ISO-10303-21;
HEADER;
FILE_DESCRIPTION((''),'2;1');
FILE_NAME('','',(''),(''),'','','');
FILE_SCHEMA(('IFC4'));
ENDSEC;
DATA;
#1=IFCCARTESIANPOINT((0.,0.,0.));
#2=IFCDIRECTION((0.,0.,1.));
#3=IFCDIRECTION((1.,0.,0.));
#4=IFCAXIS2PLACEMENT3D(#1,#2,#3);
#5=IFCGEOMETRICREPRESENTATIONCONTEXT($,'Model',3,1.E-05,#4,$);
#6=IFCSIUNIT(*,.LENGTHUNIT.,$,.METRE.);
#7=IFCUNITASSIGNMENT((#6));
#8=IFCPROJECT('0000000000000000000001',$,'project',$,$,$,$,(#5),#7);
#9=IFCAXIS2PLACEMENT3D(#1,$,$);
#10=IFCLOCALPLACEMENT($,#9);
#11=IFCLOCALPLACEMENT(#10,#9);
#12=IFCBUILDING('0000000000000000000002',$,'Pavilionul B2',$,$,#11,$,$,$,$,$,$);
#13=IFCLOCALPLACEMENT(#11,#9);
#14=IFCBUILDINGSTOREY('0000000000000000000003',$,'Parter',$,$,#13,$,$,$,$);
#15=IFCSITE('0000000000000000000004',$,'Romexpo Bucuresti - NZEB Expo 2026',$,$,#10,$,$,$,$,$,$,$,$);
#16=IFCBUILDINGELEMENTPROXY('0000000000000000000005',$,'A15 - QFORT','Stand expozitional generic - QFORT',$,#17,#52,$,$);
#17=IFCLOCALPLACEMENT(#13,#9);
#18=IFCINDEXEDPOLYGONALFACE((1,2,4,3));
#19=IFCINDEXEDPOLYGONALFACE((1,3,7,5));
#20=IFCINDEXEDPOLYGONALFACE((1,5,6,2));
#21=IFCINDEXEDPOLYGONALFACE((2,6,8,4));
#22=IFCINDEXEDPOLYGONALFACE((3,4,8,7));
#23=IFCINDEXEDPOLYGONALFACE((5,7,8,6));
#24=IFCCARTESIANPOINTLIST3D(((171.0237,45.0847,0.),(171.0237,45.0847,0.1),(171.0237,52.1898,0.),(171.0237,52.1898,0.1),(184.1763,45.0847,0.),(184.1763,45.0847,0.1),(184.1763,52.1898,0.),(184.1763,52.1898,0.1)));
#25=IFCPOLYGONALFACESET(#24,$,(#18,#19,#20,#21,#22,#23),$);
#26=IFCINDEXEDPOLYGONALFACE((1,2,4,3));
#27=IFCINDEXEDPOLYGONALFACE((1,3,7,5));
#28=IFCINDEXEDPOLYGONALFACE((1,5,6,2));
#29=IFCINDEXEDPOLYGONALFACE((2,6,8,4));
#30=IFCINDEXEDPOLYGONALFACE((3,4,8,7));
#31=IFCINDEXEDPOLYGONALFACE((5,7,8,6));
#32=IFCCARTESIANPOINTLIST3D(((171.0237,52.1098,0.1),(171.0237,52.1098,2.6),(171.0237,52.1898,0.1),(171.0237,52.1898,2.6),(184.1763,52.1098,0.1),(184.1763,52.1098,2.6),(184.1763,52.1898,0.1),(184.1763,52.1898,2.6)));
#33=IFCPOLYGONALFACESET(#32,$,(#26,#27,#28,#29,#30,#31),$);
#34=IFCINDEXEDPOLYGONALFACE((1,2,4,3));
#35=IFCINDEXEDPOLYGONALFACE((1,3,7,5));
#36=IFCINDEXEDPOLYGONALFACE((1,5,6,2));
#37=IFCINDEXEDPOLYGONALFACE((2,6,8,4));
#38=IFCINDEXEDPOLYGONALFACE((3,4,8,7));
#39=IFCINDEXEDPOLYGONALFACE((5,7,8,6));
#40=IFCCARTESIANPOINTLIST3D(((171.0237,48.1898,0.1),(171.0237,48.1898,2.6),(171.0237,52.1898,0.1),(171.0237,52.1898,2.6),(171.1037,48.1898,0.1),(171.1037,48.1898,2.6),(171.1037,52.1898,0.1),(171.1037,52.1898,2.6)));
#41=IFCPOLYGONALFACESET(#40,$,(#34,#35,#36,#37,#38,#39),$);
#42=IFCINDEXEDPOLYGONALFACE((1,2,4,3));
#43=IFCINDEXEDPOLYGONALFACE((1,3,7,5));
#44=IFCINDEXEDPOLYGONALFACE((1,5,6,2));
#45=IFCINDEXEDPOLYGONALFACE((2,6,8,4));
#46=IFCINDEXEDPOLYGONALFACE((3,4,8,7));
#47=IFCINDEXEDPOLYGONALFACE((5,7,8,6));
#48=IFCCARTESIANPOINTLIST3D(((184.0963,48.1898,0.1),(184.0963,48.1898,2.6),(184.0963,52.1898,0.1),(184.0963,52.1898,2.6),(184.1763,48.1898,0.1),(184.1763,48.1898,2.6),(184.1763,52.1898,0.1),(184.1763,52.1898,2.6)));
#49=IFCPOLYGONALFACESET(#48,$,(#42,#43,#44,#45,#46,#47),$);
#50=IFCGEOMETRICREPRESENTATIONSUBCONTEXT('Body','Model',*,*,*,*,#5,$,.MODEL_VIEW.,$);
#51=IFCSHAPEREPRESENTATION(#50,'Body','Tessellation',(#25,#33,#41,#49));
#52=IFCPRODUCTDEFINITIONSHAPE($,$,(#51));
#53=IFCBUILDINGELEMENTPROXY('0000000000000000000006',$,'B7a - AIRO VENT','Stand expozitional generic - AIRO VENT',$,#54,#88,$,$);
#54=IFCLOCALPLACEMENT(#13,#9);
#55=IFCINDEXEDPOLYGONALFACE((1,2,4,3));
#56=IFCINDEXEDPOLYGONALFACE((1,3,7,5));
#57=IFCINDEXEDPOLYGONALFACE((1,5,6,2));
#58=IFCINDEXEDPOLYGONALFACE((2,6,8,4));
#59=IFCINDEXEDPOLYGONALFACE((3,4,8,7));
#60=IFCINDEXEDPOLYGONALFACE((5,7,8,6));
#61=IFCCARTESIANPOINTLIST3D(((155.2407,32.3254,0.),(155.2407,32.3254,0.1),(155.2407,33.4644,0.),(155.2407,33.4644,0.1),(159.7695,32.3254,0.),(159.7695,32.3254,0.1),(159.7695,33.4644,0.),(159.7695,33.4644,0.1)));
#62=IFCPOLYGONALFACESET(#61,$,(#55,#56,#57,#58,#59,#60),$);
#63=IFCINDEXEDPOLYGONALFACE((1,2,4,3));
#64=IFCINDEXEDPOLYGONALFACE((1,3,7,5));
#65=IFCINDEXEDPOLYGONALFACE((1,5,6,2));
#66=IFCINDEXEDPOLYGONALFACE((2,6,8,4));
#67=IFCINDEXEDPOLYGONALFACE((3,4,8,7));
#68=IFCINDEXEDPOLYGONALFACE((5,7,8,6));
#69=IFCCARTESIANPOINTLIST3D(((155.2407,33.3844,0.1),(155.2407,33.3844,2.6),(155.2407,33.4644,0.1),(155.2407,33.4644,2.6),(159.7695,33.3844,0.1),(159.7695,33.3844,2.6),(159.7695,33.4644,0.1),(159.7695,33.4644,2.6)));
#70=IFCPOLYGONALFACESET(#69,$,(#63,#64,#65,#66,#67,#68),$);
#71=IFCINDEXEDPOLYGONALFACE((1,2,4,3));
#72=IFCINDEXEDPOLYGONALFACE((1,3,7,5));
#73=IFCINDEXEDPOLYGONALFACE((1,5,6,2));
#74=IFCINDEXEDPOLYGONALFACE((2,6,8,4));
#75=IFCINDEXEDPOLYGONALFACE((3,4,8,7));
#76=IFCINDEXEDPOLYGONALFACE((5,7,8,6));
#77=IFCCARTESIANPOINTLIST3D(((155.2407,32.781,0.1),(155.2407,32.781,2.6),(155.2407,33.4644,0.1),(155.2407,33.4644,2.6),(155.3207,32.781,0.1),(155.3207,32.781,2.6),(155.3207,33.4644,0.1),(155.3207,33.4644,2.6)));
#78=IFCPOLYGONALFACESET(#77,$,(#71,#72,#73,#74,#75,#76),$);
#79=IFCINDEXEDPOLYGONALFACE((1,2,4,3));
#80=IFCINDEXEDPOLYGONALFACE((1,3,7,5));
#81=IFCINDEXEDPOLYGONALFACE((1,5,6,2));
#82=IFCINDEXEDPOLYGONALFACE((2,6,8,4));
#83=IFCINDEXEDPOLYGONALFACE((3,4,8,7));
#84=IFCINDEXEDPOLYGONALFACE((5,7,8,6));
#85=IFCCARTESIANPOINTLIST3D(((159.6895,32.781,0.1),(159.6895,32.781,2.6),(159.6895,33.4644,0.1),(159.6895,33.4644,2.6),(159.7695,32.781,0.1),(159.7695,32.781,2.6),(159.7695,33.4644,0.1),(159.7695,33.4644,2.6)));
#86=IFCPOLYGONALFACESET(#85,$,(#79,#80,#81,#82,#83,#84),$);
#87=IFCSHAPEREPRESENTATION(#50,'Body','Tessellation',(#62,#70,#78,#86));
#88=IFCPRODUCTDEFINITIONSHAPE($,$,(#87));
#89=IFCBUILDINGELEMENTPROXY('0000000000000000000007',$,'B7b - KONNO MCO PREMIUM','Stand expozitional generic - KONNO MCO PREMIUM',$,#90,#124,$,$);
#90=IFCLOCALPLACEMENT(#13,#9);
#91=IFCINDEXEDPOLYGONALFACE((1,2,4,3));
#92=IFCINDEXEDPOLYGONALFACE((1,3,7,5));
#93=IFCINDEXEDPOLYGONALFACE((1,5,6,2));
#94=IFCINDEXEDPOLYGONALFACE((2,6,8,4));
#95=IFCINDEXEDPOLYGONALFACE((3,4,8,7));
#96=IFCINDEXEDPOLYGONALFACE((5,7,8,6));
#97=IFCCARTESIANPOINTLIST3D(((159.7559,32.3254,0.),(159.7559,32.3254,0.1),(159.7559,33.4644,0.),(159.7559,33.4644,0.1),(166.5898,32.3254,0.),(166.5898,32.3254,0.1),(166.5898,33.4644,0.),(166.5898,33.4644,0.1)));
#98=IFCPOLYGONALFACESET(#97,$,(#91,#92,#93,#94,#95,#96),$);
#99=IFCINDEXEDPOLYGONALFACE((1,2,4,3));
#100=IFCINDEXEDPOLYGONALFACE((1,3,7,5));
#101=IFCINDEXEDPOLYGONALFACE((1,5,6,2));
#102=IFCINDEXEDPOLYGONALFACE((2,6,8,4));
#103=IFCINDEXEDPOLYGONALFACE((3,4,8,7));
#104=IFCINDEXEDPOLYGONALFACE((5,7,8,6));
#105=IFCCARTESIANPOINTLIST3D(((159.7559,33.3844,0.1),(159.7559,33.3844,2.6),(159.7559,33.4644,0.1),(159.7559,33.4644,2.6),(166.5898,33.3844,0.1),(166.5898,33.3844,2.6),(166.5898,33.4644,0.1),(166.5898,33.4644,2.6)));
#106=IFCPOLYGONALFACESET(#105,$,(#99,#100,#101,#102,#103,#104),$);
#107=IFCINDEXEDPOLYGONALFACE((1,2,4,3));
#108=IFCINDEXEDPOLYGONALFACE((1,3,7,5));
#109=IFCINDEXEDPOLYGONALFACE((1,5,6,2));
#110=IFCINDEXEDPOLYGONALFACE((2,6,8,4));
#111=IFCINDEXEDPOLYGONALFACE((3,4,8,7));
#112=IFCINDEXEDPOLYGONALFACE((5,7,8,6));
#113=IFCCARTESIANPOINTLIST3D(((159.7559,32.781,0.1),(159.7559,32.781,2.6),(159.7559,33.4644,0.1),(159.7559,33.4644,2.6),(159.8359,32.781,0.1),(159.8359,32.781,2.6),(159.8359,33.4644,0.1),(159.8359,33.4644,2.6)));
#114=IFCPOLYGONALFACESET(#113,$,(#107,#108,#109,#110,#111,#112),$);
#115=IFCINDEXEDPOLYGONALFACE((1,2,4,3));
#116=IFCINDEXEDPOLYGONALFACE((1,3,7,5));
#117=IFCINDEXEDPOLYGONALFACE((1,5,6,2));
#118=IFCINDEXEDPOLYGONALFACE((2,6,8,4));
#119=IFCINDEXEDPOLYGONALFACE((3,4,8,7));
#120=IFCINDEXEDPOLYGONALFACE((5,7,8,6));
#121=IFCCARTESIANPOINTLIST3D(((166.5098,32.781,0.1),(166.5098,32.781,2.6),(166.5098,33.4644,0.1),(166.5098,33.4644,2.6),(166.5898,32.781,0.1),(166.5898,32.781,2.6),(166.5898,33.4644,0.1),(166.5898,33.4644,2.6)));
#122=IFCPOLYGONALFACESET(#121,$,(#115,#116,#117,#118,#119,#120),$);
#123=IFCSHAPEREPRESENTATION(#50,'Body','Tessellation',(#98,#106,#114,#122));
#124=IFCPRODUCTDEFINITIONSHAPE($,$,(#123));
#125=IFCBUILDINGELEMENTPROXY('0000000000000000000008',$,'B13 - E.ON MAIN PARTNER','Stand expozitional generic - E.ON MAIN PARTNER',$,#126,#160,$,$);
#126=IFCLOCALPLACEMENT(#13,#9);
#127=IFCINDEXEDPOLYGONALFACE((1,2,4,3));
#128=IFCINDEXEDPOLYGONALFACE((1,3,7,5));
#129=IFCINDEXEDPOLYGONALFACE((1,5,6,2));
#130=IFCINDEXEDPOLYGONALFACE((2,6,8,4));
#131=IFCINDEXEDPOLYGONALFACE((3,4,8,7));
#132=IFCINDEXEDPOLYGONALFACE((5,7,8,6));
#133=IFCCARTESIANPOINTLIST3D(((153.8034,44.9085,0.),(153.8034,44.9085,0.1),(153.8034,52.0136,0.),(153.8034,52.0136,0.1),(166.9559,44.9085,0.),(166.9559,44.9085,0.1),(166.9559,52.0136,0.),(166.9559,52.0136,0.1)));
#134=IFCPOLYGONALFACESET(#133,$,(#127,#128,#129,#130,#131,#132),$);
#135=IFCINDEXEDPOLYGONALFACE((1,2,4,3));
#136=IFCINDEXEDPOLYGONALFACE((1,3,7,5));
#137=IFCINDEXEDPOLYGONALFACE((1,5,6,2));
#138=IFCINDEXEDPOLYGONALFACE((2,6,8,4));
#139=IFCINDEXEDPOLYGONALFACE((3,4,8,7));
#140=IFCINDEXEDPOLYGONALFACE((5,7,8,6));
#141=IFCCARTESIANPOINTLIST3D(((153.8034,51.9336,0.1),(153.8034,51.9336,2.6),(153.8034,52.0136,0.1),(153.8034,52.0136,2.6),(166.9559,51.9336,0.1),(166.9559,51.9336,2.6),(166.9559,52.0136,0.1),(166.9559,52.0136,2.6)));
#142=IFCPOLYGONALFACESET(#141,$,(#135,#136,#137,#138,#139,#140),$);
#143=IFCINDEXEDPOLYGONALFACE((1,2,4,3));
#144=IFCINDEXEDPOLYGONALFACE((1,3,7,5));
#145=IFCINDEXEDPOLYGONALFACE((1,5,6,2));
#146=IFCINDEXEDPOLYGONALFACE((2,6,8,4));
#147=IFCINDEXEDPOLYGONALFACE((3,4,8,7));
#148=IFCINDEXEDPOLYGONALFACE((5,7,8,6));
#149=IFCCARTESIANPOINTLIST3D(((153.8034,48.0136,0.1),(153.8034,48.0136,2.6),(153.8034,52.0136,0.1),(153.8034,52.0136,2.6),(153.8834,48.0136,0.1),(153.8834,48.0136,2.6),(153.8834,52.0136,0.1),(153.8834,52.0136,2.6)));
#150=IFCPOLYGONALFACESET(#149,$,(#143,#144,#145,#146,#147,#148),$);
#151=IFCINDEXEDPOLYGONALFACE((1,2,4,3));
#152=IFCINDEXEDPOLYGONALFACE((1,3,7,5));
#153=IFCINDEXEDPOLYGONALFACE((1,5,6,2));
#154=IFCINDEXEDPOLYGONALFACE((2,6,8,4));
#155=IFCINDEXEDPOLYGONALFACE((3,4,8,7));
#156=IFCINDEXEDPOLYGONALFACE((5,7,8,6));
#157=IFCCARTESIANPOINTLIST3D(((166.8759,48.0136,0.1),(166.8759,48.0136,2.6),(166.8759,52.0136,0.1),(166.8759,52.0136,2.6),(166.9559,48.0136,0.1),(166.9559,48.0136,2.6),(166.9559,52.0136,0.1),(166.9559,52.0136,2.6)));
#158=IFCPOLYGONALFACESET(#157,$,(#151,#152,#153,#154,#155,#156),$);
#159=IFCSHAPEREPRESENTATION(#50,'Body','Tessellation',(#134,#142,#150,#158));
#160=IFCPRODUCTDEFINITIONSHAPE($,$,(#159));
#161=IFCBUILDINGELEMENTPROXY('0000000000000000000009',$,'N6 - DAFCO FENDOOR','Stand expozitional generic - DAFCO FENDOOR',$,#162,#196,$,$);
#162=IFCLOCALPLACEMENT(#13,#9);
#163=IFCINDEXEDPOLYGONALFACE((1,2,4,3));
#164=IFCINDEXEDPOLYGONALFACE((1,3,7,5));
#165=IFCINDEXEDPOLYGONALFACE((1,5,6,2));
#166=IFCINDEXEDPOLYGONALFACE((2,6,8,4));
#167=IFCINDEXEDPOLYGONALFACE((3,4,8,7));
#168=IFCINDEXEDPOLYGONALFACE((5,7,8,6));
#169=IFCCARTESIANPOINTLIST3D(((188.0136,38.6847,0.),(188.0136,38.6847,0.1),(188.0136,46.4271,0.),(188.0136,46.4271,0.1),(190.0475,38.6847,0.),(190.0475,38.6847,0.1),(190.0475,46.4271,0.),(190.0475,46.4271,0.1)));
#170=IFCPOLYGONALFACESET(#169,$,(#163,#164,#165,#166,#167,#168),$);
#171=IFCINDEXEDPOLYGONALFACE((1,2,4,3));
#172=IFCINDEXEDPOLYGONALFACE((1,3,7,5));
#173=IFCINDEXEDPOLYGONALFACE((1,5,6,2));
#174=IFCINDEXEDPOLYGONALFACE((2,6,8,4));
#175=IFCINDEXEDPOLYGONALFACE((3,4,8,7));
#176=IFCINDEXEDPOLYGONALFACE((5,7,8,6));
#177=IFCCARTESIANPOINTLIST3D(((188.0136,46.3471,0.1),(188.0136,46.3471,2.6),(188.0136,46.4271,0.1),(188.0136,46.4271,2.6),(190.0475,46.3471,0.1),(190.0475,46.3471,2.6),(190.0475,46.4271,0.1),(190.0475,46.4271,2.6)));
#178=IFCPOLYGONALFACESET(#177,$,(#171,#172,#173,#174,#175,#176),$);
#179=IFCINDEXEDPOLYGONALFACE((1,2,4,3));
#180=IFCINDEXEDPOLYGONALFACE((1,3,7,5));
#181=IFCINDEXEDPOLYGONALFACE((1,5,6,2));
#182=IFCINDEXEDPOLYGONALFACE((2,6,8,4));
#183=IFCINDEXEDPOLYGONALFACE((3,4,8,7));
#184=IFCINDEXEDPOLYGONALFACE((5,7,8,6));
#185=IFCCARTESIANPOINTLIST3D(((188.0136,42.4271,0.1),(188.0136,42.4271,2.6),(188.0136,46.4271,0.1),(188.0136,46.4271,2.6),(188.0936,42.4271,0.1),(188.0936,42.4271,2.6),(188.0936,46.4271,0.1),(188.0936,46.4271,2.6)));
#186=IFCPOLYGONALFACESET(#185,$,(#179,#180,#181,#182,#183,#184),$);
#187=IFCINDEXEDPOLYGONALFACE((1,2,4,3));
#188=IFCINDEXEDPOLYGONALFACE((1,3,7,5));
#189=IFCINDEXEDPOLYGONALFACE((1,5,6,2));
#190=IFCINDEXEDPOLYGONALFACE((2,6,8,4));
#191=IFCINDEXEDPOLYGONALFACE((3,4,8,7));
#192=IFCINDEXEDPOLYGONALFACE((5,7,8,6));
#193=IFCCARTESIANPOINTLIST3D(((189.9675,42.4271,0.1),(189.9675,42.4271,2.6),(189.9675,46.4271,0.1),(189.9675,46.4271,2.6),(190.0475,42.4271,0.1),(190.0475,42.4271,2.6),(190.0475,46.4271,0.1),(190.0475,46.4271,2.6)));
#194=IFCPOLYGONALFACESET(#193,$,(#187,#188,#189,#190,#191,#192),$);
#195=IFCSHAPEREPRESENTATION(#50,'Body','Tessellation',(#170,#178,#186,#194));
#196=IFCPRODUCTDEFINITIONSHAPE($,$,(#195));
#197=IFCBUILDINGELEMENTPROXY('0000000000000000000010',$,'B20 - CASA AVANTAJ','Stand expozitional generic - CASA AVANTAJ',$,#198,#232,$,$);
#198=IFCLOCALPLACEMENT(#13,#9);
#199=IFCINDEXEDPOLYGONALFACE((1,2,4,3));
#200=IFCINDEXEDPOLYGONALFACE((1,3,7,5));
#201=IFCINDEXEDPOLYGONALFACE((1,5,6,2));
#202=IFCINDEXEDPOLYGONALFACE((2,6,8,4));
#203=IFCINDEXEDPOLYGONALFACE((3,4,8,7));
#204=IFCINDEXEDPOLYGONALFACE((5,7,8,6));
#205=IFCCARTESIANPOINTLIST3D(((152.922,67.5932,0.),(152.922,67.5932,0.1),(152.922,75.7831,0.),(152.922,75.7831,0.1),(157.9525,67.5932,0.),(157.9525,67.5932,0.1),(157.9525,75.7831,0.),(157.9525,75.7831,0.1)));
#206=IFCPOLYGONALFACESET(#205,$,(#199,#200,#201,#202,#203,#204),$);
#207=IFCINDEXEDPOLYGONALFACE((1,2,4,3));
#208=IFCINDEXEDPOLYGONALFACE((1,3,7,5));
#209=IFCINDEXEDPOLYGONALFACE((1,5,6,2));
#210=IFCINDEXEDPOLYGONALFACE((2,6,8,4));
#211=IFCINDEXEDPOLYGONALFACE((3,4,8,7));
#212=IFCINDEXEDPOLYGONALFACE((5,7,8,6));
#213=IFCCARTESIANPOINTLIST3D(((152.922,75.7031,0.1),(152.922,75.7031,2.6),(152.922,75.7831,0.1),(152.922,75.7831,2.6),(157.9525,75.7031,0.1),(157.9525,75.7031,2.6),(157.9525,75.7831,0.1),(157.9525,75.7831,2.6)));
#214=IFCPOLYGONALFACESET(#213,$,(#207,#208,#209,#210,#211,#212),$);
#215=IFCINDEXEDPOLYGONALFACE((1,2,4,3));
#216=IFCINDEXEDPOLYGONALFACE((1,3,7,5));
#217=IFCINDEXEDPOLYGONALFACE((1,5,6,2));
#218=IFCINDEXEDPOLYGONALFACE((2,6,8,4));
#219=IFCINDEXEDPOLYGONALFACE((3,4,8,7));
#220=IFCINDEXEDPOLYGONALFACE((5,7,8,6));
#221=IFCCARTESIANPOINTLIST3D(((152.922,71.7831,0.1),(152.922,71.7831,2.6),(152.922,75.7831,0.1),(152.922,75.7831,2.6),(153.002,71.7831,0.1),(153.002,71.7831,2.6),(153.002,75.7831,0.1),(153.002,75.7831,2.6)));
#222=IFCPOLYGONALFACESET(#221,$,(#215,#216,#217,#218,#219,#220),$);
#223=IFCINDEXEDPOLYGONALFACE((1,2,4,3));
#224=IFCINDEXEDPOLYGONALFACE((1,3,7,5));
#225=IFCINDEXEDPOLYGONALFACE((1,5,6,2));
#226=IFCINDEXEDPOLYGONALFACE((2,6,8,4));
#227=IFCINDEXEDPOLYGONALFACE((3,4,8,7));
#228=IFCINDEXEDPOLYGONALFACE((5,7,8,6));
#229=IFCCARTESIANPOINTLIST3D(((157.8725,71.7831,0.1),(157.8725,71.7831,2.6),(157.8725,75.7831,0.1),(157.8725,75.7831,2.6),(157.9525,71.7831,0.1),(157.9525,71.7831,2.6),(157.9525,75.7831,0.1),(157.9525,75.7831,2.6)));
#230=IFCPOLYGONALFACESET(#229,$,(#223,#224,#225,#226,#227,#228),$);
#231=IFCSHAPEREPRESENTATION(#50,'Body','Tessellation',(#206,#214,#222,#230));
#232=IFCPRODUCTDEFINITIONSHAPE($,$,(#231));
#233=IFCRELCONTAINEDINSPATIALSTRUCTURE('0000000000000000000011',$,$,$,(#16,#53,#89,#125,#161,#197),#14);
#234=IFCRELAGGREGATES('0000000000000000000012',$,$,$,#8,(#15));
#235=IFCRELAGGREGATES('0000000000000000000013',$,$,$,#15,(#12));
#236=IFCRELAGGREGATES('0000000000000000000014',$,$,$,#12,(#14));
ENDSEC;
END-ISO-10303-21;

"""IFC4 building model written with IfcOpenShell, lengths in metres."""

from ifc_helpers import new_model, si_unit, frame, frame_2d, origin, origin_with_axes, place, context, subcontext, project, spatial, rectangle, extrude, element, save


model = new_model("IFC4")

# Units and contexts
model_context = context("Model", 3, precision=1e-05, world=origin_with_axes())
body_context = subcontext(model_context, "Body", "Model", "MODEL_VIEW")
ifc_project = project(units=[si_unit("LENGTHUNIT", "METRE")], contexts=[model_context])

# Site, building, storey
site_placement = place(None, origin())
site = spatial("IfcSite", under=ifc_project, at=site_placement, Name="Romexpo Bucuresti - NZEB Expo 2026")
building_placement = place(site_placement, origin())
building = spatial("IfcBuilding", under=site, at=building_placement, Name="Pavilionul B2")
storey_placement = place(building_placement, origin())
storey = spatial("IfcBuildingStorey", under=building, at=storey_placement, Name="Parter")

# Building element proxies
proxy_1_placement = place(storey_placement, frame((171.0237, 45.0847, 0.0), z_axis=(0.0, 0.0, 1.0), x_axis=(1.0, 0.0, 0.0)))
element("IfcBuildingElementProxy", 1, at=proxy_1_placement, inside=storey, Name="A15 - QFORT", Description="Stand expozitional generic - QFORT", context=body_context, shape_type="SweptSolid", body=[
    extrude(rectangle(XDim=13.1525, YDim=7.1051, at=frame_2d((6.5763, 3.5525))), origin(), (0.0, 0.0, 1.0), 0.1),
    extrude(rectangle(XDim=13.1525, YDim=0.08, at=frame_2d((6.5763, 7.0651))), frame((0.0, 0.0, 0.1)), (0.0, 0.0, 1.0), 2.5),
    extrude(rectangle(XDim=0.08, YDim=4.0, at=frame_2d((0.04, 5.1051))), frame((0.0, 0.0, 0.1)), (0.0, 0.0, 1.0), 2.5),
    extrude(rectangle(XDim=0.08, YDim=4.0, at=frame_2d((13.1125, 5.1051))), frame((0.0, 0.0, 0.1)), (0.0, 0.0, 1.0), 2.5),
])
proxy_2_placement = place(storey_placement, frame((155.2407, 32.3254, 0.0), z_axis=(0.0, 0.0, 1.0), x_axis=(1.0, 0.0, 0.0)))
element("IfcBuildingElementProxy", 2, at=proxy_2_placement, inside=storey, Name="B7a - AIRO VENT", Description="Stand expozitional generic - AIRO VENT", context=body_context, shape_type="SweptSolid", body=[
    extrude(rectangle(XDim=4.5288, YDim=1.139, at=frame_2d((2.2644, 0.5695))), origin(), (0.0, 0.0, 1.0), 0.1),
    extrude(rectangle(XDim=4.5288, YDim=0.08, at=frame_2d((2.2644, 1.099))), frame((0.0, 0.0, 0.1)), (0.0, 0.0, 1.0), 2.5),
    extrude(rectangle(XDim=0.08, YDim=0.6834, at=frame_2d((0.04, 0.7973))), frame((0.0, 0.0, 0.1)), (0.0, 0.0, 1.0), 2.5),
    extrude(rectangle(XDim=0.08, YDim=0.6834, at=frame_2d((4.4888, 0.7973))), frame((0.0, 0.0, 0.1)), (0.0, 0.0, 1.0), 2.5),
])
proxy_3_placement = place(storey_placement, frame((159.7559, 32.3254, 0.0), z_axis=(0.0, 0.0, 1.0), x_axis=(1.0, 0.0, 0.0)))
element("IfcBuildingElementProxy", 3, at=proxy_3_placement, inside=storey, Name="B7b - KONNO MCO PREMIUM", Description="Stand expozitional generic - KONNO MCO PREMIUM", context=body_context, shape_type="SweptSolid", body=[
    extrude(rectangle(XDim=6.8339, YDim=1.139, at=frame_2d((3.4169, 0.5695))), origin(), (0.0, 0.0, 1.0), 0.1),
    extrude(rectangle(XDim=6.8339, YDim=0.08, at=frame_2d((3.4169, 1.099))), frame((0.0, 0.0, 0.1)), (0.0, 0.0, 1.0), 2.5),
    extrude(rectangle(XDim=0.08, YDim=0.6834, at=frame_2d((0.04, 0.7973))), frame((0.0, 0.0, 0.1)), (0.0, 0.0, 1.0), 2.5),
    extrude(rectangle(XDim=0.08, YDim=0.6834, at=frame_2d((6.7939, 0.7973))), frame((0.0, 0.0, 0.1)), (0.0, 0.0, 1.0), 2.5),
])
proxy_4_placement = place(storey_placement, frame((153.8034, 44.9085, 0.0), z_axis=(0.0, 0.0, 1.0), x_axis=(1.0, 0.0, 0.0)))
element("IfcBuildingElementProxy", 4, at=proxy_4_placement, inside=storey, Name="B13 - E.ON MAIN PARTNER", Description="Stand expozitional generic - E.ON MAIN PARTNER", context=body_context, shape_type="SweptSolid", body=[
    extrude(rectangle(XDim=13.1525, YDim=7.1051, at=frame_2d((6.5763, 3.5525))), origin(), (0.0, 0.0, 1.0), 0.1),
    extrude(rectangle(XDim=13.1525, YDim=0.08, at=frame_2d((6.5763, 7.0651))), frame((0.0, 0.0, 0.1)), (0.0, 0.0, 1.0), 2.5),
    extrude(rectangle(XDim=0.08, YDim=4.0, at=frame_2d((0.04, 5.1051))), frame((0.0, 0.0, 0.1)), (0.0, 0.0, 1.0), 2.5),
    extrude(rectangle(XDim=0.08, YDim=4.0, at=frame_2d((13.1125, 5.1051))), frame((0.0, 0.0, 0.1)), (0.0, 0.0, 1.0), 2.5),
])
proxy_5_placement = place(storey_placement, frame((188.0136, 38.6847, 0.0), z_axis=(0.0, 0.0, 1.0), x_axis=(1.0, 0.0, 0.0)))
element("IfcBuildingElementProxy", 5, at=proxy_5_placement, inside=storey, Name="N6 - DAFCO FENDOOR", Description="Stand expozitional generic - DAFCO FENDOOR", context=body_context, shape_type="SweptSolid", body=[
    extrude(rectangle(XDim=2.0339, YDim=7.7424, at=frame_2d((1.0169, 3.8712))), origin(), (0.0, 0.0, 1.0), 0.1),
    extrude(rectangle(XDim=2.0339, YDim=0.08, at=frame_2d((1.0169, 7.7024))), frame((0.0, 0.0, 0.1)), (0.0, 0.0, 1.0), 2.5),
    extrude(rectangle(XDim=0.08, YDim=4.0, at=frame_2d((0.04, 5.7424))), frame((0.0, 0.0, 0.1)), (0.0, 0.0, 1.0), 2.5),
    extrude(rectangle(XDim=0.08, YDim=4.0, at=frame_2d((1.9939, 5.7424))), frame((0.0, 0.0, 0.1)), (0.0, 0.0, 1.0), 2.5),
])
proxy_6_placement = place(storey_placement, frame((152.922, 67.5932, 0.0), z_axis=(0.0, 0.0, 1.0), x_axis=(1.0, 0.0, 0.0)))
element("IfcBuildingElementProxy", 6, at=proxy_6_placement, inside=storey, Name="B20 - CASA AVANTAJ", Description="Stand expozitional generic - CASA AVANTAJ", context=body_context, shape_type="SweptSolid", body=[
    extrude(rectangle(XDim=5.0305, YDim=8.1898, at=frame_2d((2.5153, 4.0949))), origin(), (0.0, 0.0, 1.0), 0.1),
    extrude(rectangle(XDim=5.0305, YDim=0.08, at=frame_2d((2.5153, 8.1498))), frame((0.0, 0.0, 0.1)), (0.0, 0.0, 1.0), 2.5),
    extrude(rectangle(XDim=0.08, YDim=4.0, at=frame_2d((0.04, 6.1898))), frame((0.0, 0.0, 0.1)), (0.0, 0.0, 1.0), 2.5),
    extrude(rectangle(XDim=0.08, YDim=4.0, at=frame_2d((4.9905, 6.1898))), frame((0.0, 0.0, 0.1)), (0.0, 0.0, 1.0), 2.5),
])

save(model, "model.ifc")
